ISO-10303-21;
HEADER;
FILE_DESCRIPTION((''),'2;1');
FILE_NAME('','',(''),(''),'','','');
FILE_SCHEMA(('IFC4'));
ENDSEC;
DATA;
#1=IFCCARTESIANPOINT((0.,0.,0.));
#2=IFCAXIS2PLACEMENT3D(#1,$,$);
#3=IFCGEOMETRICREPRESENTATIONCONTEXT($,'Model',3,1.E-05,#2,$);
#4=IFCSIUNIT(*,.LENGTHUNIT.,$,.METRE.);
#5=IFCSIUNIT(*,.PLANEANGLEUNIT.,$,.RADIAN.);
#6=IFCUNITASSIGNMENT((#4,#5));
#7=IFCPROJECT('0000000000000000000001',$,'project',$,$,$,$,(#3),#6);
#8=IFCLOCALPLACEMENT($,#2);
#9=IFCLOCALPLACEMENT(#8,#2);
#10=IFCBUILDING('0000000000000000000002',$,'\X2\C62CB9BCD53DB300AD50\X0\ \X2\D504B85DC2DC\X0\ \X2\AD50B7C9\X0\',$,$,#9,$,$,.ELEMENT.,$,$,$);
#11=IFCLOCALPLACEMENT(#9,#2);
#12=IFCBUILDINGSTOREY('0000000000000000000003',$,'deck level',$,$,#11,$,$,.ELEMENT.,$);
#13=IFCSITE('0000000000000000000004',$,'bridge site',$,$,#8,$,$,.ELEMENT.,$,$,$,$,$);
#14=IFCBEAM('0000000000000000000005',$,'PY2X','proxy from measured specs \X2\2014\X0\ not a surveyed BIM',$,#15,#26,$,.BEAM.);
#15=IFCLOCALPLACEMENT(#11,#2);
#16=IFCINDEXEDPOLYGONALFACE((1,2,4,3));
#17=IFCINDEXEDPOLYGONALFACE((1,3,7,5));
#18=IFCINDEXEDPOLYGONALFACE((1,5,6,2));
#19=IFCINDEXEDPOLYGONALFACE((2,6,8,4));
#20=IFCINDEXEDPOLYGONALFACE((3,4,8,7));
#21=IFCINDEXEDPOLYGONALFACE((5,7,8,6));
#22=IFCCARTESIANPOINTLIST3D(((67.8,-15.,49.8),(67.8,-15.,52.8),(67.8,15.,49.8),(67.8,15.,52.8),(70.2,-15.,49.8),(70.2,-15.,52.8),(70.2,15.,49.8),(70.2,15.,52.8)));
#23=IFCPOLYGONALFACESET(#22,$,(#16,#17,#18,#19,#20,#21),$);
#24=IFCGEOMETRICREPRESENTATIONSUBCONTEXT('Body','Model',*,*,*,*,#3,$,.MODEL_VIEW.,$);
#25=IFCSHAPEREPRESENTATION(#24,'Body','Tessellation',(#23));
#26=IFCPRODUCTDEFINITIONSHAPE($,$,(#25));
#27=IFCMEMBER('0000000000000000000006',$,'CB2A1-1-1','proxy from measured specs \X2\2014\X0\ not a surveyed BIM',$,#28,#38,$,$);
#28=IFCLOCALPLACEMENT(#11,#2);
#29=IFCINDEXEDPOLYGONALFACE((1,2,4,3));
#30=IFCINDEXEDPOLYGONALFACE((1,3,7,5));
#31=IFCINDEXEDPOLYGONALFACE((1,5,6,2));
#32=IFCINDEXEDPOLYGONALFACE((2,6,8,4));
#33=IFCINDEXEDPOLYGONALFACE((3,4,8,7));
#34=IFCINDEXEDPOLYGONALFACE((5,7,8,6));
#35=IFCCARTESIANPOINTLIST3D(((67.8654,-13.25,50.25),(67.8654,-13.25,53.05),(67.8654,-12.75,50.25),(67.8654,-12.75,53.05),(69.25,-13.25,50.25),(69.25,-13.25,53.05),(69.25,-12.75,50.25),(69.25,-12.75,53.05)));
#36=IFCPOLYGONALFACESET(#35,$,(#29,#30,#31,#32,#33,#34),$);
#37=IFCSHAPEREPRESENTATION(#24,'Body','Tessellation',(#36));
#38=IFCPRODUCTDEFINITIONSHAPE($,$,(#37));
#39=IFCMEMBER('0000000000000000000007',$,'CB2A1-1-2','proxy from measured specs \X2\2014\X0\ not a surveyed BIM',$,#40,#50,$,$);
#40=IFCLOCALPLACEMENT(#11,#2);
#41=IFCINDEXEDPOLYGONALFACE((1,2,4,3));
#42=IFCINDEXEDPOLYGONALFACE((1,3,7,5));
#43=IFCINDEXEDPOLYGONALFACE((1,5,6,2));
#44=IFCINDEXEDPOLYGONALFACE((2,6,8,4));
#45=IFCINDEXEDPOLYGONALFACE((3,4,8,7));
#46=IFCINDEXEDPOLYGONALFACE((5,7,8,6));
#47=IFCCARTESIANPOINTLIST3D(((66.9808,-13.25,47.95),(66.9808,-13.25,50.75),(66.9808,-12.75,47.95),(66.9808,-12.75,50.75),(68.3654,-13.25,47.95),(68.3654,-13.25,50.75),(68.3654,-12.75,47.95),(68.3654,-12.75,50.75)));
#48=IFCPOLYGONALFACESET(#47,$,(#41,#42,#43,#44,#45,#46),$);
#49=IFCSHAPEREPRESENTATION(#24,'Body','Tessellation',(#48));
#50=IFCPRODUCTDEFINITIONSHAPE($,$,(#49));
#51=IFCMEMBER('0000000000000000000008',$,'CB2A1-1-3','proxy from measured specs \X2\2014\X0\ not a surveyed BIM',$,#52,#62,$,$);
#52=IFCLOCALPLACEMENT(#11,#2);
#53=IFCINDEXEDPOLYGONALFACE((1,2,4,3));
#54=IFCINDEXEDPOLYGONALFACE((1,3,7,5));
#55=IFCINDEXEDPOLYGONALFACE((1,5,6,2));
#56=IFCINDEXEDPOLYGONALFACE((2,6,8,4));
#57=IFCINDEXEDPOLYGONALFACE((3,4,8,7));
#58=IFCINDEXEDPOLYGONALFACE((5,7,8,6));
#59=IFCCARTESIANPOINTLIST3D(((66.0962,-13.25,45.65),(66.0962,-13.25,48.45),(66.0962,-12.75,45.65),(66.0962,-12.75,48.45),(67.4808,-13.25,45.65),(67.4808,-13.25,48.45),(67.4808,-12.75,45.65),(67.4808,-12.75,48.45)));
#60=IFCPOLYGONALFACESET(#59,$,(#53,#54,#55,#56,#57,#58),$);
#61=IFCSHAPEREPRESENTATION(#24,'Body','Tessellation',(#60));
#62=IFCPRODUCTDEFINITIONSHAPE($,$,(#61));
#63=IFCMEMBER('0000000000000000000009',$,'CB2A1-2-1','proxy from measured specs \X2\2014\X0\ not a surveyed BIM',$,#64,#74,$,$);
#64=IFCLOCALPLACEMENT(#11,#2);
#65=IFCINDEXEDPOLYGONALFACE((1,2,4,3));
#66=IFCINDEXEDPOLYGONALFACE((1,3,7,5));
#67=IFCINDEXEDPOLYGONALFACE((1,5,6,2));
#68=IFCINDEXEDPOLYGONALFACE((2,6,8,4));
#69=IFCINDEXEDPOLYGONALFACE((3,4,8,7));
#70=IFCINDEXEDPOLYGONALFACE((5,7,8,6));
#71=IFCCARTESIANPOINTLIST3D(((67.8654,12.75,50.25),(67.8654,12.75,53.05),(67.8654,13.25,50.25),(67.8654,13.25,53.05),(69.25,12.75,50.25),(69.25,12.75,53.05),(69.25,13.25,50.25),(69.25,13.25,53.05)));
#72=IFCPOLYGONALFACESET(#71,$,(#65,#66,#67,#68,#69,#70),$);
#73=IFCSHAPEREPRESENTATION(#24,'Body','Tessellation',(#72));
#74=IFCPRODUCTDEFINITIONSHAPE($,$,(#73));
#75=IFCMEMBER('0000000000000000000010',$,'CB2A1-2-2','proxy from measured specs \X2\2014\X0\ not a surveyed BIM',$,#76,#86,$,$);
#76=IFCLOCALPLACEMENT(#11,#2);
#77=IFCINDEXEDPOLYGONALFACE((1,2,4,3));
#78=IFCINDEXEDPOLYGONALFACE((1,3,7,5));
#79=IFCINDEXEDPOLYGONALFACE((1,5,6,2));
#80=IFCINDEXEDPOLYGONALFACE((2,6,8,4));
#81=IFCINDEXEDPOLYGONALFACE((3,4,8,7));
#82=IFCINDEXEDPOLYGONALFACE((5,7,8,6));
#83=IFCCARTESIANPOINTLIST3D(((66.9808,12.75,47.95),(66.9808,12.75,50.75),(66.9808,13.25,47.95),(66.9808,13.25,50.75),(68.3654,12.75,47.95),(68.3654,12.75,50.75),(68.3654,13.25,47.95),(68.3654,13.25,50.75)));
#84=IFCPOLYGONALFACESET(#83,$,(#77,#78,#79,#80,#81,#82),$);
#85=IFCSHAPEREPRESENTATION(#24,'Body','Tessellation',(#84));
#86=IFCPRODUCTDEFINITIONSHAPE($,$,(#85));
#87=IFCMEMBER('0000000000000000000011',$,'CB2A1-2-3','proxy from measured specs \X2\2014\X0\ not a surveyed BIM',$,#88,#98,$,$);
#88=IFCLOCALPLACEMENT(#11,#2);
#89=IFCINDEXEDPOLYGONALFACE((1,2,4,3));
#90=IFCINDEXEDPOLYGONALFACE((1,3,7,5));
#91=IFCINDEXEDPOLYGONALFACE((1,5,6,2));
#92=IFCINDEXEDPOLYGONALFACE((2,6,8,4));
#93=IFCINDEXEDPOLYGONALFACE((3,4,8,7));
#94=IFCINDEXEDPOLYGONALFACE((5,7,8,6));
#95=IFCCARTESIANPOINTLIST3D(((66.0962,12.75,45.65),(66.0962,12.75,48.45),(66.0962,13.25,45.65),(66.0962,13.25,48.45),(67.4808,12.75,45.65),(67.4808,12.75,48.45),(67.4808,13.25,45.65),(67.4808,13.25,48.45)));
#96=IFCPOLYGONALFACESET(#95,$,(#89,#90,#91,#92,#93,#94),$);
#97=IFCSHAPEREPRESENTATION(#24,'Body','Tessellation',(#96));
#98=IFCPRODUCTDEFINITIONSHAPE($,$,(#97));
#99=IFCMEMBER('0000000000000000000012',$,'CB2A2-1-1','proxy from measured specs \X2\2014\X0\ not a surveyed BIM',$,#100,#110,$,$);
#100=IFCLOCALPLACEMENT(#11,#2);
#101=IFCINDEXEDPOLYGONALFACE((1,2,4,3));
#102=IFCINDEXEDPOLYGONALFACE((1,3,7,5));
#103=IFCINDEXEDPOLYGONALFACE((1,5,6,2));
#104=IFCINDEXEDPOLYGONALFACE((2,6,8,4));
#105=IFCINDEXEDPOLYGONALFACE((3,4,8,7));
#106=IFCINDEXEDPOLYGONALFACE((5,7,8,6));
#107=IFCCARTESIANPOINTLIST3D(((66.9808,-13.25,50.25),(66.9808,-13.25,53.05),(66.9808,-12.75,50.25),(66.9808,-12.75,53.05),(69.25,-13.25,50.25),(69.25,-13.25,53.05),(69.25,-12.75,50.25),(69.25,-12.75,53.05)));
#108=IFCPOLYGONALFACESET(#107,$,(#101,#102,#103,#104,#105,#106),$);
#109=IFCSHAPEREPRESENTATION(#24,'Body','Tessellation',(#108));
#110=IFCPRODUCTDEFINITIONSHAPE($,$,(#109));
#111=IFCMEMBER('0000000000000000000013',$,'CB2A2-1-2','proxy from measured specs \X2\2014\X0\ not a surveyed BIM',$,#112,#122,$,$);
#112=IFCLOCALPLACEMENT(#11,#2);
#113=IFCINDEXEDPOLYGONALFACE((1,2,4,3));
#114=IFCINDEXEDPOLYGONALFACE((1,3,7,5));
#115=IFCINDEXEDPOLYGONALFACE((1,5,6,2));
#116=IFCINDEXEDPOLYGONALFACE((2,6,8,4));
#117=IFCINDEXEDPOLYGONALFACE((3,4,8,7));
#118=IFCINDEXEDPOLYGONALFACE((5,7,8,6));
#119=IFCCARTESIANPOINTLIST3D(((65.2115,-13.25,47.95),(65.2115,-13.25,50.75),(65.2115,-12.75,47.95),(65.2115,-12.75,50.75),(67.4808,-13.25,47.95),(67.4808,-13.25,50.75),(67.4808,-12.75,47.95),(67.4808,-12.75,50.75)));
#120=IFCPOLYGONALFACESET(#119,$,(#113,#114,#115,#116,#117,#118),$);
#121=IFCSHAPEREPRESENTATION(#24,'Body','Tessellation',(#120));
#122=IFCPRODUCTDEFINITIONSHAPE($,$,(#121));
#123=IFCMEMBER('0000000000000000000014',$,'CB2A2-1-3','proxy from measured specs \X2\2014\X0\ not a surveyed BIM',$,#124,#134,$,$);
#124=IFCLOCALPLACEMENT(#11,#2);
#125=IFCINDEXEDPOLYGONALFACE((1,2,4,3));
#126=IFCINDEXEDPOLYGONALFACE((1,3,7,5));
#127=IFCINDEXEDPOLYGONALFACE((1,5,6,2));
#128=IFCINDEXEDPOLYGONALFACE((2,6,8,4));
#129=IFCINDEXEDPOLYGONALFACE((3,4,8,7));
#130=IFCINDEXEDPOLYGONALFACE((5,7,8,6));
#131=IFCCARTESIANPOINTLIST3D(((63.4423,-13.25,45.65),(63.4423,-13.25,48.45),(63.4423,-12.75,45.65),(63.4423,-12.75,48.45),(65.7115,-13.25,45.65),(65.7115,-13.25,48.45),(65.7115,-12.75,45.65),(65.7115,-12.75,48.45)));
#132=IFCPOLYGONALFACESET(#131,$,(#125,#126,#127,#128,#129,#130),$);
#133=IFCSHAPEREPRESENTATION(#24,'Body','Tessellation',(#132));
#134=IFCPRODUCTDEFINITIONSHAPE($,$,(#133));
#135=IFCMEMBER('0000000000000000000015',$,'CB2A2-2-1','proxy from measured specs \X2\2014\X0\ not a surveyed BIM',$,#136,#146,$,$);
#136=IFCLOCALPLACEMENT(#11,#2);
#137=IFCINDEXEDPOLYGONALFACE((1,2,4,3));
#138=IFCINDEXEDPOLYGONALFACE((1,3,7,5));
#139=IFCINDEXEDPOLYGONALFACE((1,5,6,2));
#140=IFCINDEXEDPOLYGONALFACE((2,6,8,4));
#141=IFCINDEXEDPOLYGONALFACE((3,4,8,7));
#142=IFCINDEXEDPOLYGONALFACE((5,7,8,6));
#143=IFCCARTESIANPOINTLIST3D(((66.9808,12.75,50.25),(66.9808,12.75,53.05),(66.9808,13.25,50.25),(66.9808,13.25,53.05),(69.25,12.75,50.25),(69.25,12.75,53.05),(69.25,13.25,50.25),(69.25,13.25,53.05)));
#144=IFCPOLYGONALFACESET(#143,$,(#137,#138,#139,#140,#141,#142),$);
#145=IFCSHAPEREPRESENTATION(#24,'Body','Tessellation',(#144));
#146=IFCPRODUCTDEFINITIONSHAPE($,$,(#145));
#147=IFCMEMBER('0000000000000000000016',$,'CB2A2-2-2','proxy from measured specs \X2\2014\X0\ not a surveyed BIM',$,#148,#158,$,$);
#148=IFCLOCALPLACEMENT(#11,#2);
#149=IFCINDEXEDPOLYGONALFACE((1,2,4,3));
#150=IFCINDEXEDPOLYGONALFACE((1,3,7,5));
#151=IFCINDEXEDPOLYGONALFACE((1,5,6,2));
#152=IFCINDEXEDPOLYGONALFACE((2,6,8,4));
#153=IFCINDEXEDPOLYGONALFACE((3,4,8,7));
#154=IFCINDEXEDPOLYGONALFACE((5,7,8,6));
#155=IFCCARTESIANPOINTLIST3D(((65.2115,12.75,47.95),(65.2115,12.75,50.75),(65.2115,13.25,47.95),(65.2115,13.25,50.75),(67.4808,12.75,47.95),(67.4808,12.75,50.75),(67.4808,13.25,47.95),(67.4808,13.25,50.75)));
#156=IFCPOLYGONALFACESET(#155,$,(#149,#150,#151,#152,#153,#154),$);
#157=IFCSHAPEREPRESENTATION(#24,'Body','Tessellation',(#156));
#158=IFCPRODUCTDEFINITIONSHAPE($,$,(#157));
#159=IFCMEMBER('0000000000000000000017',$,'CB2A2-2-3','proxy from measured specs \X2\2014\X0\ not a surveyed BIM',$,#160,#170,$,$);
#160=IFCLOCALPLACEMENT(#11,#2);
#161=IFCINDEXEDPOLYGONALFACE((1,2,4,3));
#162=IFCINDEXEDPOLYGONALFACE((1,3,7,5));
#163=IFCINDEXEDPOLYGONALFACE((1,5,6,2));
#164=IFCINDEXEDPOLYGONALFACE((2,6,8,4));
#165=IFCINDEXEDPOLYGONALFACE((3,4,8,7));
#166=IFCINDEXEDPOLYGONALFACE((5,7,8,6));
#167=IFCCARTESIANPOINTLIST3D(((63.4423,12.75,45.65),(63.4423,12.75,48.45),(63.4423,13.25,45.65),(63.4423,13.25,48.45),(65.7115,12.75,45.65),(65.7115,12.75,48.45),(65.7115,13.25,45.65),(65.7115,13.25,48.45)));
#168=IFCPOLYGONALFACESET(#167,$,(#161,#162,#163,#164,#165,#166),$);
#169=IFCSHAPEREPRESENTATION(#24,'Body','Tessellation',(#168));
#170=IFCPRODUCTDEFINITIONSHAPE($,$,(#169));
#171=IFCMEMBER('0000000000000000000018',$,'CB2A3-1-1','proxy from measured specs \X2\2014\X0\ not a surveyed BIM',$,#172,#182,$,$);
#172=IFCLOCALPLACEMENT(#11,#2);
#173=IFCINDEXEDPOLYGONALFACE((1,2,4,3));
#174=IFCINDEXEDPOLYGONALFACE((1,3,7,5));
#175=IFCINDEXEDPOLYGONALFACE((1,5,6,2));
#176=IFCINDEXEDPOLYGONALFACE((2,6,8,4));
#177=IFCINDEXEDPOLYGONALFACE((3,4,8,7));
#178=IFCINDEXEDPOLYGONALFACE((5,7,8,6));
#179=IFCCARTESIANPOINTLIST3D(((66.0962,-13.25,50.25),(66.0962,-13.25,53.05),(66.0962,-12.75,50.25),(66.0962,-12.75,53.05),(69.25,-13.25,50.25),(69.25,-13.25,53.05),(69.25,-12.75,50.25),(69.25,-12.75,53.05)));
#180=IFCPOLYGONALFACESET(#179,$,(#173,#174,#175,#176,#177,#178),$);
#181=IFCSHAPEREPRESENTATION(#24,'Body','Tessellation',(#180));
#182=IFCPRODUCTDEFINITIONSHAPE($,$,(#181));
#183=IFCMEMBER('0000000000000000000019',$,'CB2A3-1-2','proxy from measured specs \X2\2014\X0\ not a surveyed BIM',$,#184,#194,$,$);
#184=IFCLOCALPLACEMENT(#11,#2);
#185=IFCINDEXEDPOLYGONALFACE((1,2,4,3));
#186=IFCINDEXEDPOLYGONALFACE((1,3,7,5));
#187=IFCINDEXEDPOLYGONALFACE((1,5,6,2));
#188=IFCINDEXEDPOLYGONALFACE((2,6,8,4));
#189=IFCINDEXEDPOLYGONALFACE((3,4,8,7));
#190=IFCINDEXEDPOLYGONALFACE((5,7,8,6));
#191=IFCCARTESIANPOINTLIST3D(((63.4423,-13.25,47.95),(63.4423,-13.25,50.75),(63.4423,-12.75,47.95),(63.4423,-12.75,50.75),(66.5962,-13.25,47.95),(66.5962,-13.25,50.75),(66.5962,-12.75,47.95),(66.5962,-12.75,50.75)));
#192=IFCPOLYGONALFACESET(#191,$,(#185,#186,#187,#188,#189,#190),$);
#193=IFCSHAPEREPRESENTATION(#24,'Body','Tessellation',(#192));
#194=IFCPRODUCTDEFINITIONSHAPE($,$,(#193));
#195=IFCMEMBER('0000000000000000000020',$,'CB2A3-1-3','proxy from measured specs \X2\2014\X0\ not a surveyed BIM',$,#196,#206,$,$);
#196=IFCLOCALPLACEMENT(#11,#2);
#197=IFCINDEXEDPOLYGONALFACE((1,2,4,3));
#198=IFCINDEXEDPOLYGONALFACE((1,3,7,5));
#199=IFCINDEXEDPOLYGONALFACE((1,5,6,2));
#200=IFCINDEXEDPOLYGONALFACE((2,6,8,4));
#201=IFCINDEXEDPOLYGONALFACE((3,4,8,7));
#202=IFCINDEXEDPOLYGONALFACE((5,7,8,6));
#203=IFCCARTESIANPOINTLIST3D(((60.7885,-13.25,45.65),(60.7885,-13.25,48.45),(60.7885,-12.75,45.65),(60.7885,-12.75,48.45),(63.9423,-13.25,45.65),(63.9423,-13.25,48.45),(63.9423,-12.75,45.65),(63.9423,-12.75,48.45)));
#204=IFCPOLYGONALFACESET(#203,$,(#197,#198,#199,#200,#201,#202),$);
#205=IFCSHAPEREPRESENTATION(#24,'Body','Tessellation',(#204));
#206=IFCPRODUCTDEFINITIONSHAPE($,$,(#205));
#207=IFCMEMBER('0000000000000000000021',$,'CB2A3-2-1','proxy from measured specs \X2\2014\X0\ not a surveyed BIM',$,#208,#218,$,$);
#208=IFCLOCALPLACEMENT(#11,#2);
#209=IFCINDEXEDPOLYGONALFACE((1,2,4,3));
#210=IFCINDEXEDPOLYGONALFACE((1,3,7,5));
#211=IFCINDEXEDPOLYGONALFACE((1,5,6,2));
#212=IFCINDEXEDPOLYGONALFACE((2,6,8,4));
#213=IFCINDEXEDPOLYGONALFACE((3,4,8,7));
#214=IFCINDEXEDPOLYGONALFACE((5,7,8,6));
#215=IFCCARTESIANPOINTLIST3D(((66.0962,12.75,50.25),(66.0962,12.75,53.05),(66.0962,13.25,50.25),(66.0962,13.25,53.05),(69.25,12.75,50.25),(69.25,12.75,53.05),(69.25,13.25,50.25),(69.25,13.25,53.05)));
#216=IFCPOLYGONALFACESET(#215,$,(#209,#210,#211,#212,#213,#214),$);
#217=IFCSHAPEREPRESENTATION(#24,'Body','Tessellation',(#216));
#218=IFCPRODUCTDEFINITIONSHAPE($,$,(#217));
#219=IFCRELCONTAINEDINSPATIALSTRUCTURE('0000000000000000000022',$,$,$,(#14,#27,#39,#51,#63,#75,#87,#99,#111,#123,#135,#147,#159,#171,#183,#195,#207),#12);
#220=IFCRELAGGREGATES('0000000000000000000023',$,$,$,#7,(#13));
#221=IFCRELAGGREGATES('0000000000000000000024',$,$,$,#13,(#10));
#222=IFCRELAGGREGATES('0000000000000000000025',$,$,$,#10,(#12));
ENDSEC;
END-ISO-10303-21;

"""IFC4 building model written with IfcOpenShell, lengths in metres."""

from ifc_helpers import new_model, si_unit, frame, origin, origin_2d, place, context, subcontext, project, spatial, rectangle, extrude, element, save


model = new_model("IFC4")

# Units and contexts
model_context = context("Model", 3, precision=1e-05, world=origin())
body_context = subcontext(model_context, "Body", "Model", "MODEL_VIEW")
ifc_project = project(units=[si_unit("LENGTHUNIT", "METRE"), si_unit("PLANEANGLEUNIT", "RADIAN")], contexts=[model_context])

# Site, building, storey
site_placement = place(None, origin())
site = spatial("IfcSite", under=ifc_project, at=site_placement, Name="bridge site", CompositionType="ELEMENT")
building_placement = place(site_placement, origin())
building = spatial("IfcBuilding", under=site, at=building_placement, Name="올림픽대교 프록시 교량", CompositionType="ELEMENT")
storey_placement = place(building_placement, origin())
storey = spatial("IfcBuildingStorey", under=building, at=storey_placement, Name="deck level", CompositionType="ELEMENT")

# Beam
beam_placement = place(storey_placement, frame((69.0, 0.0, 49.8)))
element("IfcBeam", 1, at=beam_placement, inside=storey, Name="PY2X", Description="proxy from measured specs — not a surveyed BIM", PredefinedType="BEAM", context=body_context, shape_type="SweptSolid", body=[
    extrude(rectangle(XDim=2.4, YDim=30.0, at=origin_2d()), origin(), (0.0, 0.0, 1.0), 3.0),
])

# Members
member_1_placement = place(storey_placement, frame((68.5577, -13.0, 50.25)))
element("IfcMember", 2, at=member_1_placement, inside=storey, Name="CB2A1-1-1", Description="proxy from measured specs — not a surveyed BIM", context=body_context, shape_type="SweptSolid", body=[
    extrude(rectangle(XDim=1.3846, YDim=0.5, at=origin_2d()), origin(), (0.0, 0.0, 1.0), 2.8),
])
member_2_placement = place(storey_placement, frame((67.6731, -13.0, 47.95)))
element("IfcMember", 3, at=member_2_placement, inside=storey, Name="CB2A1-1-2", Description="proxy from measured specs — not a surveyed BIM", context=body_context, shape_type="SweptSolid", body=[
    extrude(rectangle(XDim=1.3846, YDim=0.5, at=origin_2d()), origin(), (0.0, 0.0, 1.0), 2.8),
])
for number, where, name in (
    (4, (66.7885, -13.0, 45.65), "CB2A1-1-3"),
    (5, (68.5577, 13.0, 50.25), "CB2A1-2-1"),
):
    element("IfcMember", number, at=place(storey_placement, frame(where)), inside=storey, Name=name, Description="proxy from measured specs — not a surveyed BIM", context=body_context, shape_type="SweptSolid", body=[
        extrude(rectangle(XDim=1.3846, YDim=0.5, at=origin_2d()), origin(), (0.0, 0.0, 1.0), 2.8),
    ])
member_3_placement = place(storey_placement, frame((67.6731, 13.0, 47.95)))
element("IfcMember", 6, at=member_3_placement, inside=storey, Name="CB2A1-2-2", Description="proxy from measured specs — not a surveyed BIM", context=body_context, shape_type="SweptSolid", body=[
    extrude(rectangle(XDim=1.3846, YDim=0.5, at=origin_2d()), origin(), (0.0, 0.0, 1.0), 2.8),
])
member_4_placement = place(storey_placement, frame((66.7885, 13.0, 45.65)))
element("IfcMember", 7, at=member_4_placement, inside=storey, Name="CB2A1-2-3", Description="proxy from measured specs — not a surveyed BIM", context=body_context, shape_type="SweptSolid", body=[
    extrude(rectangle(XDim=1.3846, YDim=0.5, at=origin_2d()), origin(), (0.0, 0.0, 1.0), 2.8),
])
member_5_placement = place(storey_placement, frame((68.1154, -13.0, 50.25)))
element("IfcMember", 8, at=member_5_placement, inside=storey, Name="CB2A2-1-1", Description="proxy from measured specs — not a surveyed BIM", context=body_context, shape_type="SweptSolid", body=[
    extrude(rectangle(XDim=2.2692, YDim=0.5, at=origin_2d()), origin(), (0.0, 0.0, 1.0), 2.8),
])
member_6_placement = place(storey_placement, frame((66.3462, -13.0, 47.95)))
element("IfcMember", 9, at=member_6_placement, inside=storey, Name="CB2A2-1-2", Description="proxy from measured specs — not a surveyed BIM", context=body_context, shape_type="SweptSolid", body=[
    extrude(rectangle(XDim=2.2692, YDim=0.5, at=origin_2d()), origin(), (0.0, 0.0, 1.0), 2.8),
])
for number, where, name in (
    (10, (64.5769, -13.0, 45.65), "CB2A2-1-3"),
    (11, (68.1154, 13.0, 50.25), "CB2A2-2-1"),
):
    element("IfcMember", number, at=place(storey_placement, frame(where)), inside=storey, Name=name, Description="proxy from measured specs — not a surveyed BIM", context=body_context, shape_type="SweptSolid", body=[
        extrude(rectangle(XDim=2.2692, YDim=0.5, at=origin_2d()), origin(), (0.0, 0.0, 1.0), 2.8),
    ])
member_7_placement = place(storey_placement, frame((66.3462, 13.0, 47.95)))
element("IfcMember", 12, at=member_7_placement, inside=storey, Name="CB2A2-2-2", Description="proxy from measured specs — not a surveyed BIM", context=body_context, shape_type="SweptSolid", body=[
    extrude(rectangle(XDim=2.2692, YDim=0.5, at=origin_2d()), origin(), (0.0, 0.0, 1.0), 2.8),
])
member_8_placement = place(storey_placement, frame((64.5769, 13.0, 45.65)))
element("IfcMember", 13, at=member_8_placement, inside=storey, Name="CB2A2-2-3", Description="proxy from measured specs — not a surveyed BIM", context=body_context, shape_type="SweptSolid", body=[
    extrude(rectangle(XDim=2.2692, YDim=0.5, at=origin_2d()), origin(), (0.0, 0.0, 1.0), 2.8),
])
member_9_placement = place(storey_placement, frame((67.6731, -13.0, 50.25)))
element("IfcMember", 14, at=member_9_placement, inside=storey, Name="CB2A3-1-1", Description="proxy from measured specs — not a surveyed BIM", context=body_context, shape_type="SweptSolid", body=[
    extrude(rectangle(XDim=3.1538, YDim=0.5, at=origin_2d()), origin(), (0.0, 0.0, 1.0), 2.8),
])
member_10_placement = place(storey_placement, frame((65.0192, -13.0, 47.95)))
element("IfcMember", 15, at=member_10_placement, inside=storey, Name="CB2A3-1-2", Description="proxy from measured specs — not a surveyed BIM", context=body_context, shape_type="SweptSolid", body=[
    extrude(rectangle(XDim=3.1538, YDim=0.5, at=origin_2d()), origin(), (0.0, 0.0, 1.0), 2.8),
])
member_11_placement = place(storey_placement, frame((62.3654, -13.0, 45.65)))
element("IfcMember", 16, at=member_11_placement, inside=storey, Name="CB2A3-1-3", Description="proxy from measured specs — not a surveyed BIM", context=body_context, shape_type="SweptSolid", body=[
    extrude(rectangle(XDim=3.1538, YDim=0.5, at=origin_2d()), origin(), (0.0, 0.0, 1.0), 2.8),
])
member_12_placement = place(storey_placement, frame((67.6731, 13.0, 50.25)))
element("IfcMember", 17, at=member_12_placement, inside=storey, Name="CB2A3-2-1", Description="proxy from measured specs — not a surveyed BIM", context=body_context, shape_type="SweptSolid", body=[
    extrude(rectangle(XDim=3.1538, YDim=0.5, at=origin_2d()), origin(), (0.0, 0.0, 1.0), 2.8),
])

save(model, "model.ifc")
